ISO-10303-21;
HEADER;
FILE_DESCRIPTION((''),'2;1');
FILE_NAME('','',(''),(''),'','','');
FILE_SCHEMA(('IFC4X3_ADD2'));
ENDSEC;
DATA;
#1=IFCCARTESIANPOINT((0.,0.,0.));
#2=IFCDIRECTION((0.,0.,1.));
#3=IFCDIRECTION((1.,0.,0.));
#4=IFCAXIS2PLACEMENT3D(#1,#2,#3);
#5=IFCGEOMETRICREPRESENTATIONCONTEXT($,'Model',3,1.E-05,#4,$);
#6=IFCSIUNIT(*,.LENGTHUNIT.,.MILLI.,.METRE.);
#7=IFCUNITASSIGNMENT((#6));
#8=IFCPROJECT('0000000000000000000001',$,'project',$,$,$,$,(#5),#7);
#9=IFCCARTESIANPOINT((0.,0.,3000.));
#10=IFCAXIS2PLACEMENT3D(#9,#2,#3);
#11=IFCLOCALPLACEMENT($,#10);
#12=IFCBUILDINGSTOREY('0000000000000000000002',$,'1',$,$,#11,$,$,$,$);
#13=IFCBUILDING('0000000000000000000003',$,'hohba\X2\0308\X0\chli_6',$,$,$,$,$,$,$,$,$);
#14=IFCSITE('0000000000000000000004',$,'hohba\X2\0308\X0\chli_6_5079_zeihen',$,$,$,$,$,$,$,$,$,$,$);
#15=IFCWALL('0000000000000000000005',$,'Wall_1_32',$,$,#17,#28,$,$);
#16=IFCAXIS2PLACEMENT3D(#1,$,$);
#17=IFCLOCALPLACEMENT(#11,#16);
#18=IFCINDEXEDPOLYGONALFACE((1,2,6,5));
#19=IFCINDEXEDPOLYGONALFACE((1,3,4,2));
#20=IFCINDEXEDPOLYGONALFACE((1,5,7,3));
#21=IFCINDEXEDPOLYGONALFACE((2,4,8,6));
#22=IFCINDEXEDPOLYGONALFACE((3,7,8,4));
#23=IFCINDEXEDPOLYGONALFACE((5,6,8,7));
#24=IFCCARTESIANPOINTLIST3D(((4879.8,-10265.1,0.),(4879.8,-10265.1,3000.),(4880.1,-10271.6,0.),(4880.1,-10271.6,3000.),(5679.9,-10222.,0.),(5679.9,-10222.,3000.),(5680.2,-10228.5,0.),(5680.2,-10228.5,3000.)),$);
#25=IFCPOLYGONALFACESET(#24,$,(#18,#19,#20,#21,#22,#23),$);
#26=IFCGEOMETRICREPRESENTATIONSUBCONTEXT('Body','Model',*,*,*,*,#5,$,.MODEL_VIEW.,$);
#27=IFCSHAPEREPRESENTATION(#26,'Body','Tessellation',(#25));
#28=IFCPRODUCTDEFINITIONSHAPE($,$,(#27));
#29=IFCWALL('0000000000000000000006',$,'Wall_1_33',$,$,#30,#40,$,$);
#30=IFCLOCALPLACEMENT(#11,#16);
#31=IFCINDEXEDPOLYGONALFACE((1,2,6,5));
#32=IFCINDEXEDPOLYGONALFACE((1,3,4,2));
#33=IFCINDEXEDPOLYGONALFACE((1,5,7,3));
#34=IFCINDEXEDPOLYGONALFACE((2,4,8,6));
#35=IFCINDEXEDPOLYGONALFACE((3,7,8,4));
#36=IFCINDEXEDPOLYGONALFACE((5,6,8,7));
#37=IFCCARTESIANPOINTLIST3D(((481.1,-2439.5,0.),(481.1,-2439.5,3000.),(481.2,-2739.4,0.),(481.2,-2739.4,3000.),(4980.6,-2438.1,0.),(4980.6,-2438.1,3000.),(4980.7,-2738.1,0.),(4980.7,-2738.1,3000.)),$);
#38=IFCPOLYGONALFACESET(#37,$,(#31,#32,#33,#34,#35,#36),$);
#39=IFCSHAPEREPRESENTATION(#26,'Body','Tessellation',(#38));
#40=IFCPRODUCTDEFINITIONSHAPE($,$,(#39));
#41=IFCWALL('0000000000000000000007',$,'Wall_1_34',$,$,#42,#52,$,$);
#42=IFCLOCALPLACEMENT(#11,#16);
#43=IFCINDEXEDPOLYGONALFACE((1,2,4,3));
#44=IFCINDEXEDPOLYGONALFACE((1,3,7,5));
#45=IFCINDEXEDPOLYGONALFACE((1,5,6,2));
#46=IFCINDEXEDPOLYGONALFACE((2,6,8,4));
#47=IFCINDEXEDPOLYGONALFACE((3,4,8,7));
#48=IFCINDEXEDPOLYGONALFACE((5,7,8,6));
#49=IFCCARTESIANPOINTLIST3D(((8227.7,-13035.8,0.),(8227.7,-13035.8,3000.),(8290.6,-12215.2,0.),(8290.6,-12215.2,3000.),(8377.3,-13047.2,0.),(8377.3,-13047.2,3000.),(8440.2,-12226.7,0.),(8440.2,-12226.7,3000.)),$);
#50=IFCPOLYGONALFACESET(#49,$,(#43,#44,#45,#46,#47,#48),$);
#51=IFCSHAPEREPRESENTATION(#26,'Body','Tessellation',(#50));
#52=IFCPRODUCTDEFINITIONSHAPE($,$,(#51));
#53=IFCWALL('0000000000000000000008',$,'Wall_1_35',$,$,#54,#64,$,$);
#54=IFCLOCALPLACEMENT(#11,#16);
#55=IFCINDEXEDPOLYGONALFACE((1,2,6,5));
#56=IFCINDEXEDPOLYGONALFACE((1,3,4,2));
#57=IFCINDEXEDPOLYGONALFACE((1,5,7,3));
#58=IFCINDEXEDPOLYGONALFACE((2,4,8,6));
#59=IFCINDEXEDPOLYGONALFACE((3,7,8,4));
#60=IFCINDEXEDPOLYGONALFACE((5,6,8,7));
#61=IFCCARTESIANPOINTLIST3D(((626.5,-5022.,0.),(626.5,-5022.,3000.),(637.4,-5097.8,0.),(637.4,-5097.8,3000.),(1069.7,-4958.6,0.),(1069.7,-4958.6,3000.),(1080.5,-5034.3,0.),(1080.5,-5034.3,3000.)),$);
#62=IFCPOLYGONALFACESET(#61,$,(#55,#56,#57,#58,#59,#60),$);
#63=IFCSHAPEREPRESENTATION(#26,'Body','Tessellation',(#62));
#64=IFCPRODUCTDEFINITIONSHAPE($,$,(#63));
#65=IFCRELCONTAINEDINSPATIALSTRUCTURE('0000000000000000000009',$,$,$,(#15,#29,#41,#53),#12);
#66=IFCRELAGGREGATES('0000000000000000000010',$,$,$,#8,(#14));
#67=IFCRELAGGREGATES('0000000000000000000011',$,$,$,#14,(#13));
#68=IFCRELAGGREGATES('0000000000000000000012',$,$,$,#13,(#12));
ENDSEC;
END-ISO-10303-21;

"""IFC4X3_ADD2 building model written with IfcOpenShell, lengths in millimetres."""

from ifc_helpers import new_model, si_unit, frame, origin_with_axes, place, context, subcontext, project, spatial, indexed_curve, outline, extrude, element, save


model = new_model("IFC4X3_ADD2")

# Units and contexts
model_context = context("Model", 3, precision=1e-05, world=origin_with_axes())
body_context = subcontext(model_context, "Body", "Model", "MODEL_VIEW")
ifc_project = project(units=[si_unit("LENGTHUNIT", "METRE", prefix="MILLI")], contexts=[model_context])

# Site, building, storey
site = spatial("IfcSite", under=ifc_project, Name="hohbächli_6_5079_zeihen")
building = spatial("IfcBuilding", under=site, Name="hohbächli_6")
storey_placement = place(None, frame((0.0, 0.0, 3000.0), z_axis=(0.0, 0.0, 1.0), x_axis=(1.0, 0.0, 0.0)))
storey = spatial("IfcBuildingStorey", under=building, at=storey_placement, Name="1")

# Walls
wall_1_placement = place(storey_placement, frame((5679.9, -10222.0, 0.0), z_axis=(0.0, 0.0, 1.0), x_axis=(-0.998552, -0.053797, 0.0)))
element("IfcWall", 1, at=wall_1_placement, inside=storey, Name="Wall_1_32", context=body_context, shape_type="SweptSolid", body=[
    extrude(outline(indexed_curve([(0.0, 0.0), (0.0, 6.5), (801.3, 6.5), (801.3, 0.0), (0.0, 0.0)], self_intersect=False)), origin_with_axes(), (0.0, 0.0, 1.0), 3000.0),
])
wall_2_placement = place(storey_placement, frame((481.2, -2739.4, 0.0), z_axis=(0.0, 0.0, 1.0), x_axis=(1.0, 0.000302, 0.0)))
element("IfcWall", 2, at=wall_2_placement, inside=storey, Name="Wall_1_33", context=body_context, shape_type="SweptSolid", body=[
    extrude(outline(indexed_curve([(0.0, 0.0), (0.0, 300.0), (4499.5, 300.0), (4499.5, 0.0), (0.0, 0.0)], self_intersect=False)), origin_with_axes(), (0.0, 0.0, 1.0), 3000.0),
])
wall_3_placement = place(storey_placement, frame((8290.6, -12215.2, 0.0), z_axis=(0.0, 0.0, 1.0), x_axis=(-0.076395, -0.997078, 0.0)))
element("IfcWall", 3, at=wall_3_placement, inside=storey, Name="Wall_1_34", context=body_context, shape_type="SweptSolid", body=[
    extrude(outline(indexed_curve([(0.0, 0.0), (0.0, 150.0), (823.0, 150.0), (823.0, 0.0), (0.0, 0.0)], self_intersect=False)), origin_with_axes(), (0.0, 0.0, 1.0), 3000.0),
])
wall_4_placement = place(storey_placement, frame((1069.7, -4958.6, 0.0), z_axis=(0.0, 0.0, 1.0), x_axis=(-0.989907, -0.141721, 0.0)))
element("IfcWall", 4, at=wall_4_placement, inside=storey, Name="Wall_1_35", context=body_context, shape_type="SweptSolid", body=[
    extrude(outline(indexed_curve([(0.0, 0.0), (0.0, 76.5), (447.7, 76.5), (447.7, 0.0), (0.0, 0.0)], self_intersect=False)), origin_with_axes(), (0.0, 0.0, 1.0), 3000.0),
])

save(model, "model.ifc")
